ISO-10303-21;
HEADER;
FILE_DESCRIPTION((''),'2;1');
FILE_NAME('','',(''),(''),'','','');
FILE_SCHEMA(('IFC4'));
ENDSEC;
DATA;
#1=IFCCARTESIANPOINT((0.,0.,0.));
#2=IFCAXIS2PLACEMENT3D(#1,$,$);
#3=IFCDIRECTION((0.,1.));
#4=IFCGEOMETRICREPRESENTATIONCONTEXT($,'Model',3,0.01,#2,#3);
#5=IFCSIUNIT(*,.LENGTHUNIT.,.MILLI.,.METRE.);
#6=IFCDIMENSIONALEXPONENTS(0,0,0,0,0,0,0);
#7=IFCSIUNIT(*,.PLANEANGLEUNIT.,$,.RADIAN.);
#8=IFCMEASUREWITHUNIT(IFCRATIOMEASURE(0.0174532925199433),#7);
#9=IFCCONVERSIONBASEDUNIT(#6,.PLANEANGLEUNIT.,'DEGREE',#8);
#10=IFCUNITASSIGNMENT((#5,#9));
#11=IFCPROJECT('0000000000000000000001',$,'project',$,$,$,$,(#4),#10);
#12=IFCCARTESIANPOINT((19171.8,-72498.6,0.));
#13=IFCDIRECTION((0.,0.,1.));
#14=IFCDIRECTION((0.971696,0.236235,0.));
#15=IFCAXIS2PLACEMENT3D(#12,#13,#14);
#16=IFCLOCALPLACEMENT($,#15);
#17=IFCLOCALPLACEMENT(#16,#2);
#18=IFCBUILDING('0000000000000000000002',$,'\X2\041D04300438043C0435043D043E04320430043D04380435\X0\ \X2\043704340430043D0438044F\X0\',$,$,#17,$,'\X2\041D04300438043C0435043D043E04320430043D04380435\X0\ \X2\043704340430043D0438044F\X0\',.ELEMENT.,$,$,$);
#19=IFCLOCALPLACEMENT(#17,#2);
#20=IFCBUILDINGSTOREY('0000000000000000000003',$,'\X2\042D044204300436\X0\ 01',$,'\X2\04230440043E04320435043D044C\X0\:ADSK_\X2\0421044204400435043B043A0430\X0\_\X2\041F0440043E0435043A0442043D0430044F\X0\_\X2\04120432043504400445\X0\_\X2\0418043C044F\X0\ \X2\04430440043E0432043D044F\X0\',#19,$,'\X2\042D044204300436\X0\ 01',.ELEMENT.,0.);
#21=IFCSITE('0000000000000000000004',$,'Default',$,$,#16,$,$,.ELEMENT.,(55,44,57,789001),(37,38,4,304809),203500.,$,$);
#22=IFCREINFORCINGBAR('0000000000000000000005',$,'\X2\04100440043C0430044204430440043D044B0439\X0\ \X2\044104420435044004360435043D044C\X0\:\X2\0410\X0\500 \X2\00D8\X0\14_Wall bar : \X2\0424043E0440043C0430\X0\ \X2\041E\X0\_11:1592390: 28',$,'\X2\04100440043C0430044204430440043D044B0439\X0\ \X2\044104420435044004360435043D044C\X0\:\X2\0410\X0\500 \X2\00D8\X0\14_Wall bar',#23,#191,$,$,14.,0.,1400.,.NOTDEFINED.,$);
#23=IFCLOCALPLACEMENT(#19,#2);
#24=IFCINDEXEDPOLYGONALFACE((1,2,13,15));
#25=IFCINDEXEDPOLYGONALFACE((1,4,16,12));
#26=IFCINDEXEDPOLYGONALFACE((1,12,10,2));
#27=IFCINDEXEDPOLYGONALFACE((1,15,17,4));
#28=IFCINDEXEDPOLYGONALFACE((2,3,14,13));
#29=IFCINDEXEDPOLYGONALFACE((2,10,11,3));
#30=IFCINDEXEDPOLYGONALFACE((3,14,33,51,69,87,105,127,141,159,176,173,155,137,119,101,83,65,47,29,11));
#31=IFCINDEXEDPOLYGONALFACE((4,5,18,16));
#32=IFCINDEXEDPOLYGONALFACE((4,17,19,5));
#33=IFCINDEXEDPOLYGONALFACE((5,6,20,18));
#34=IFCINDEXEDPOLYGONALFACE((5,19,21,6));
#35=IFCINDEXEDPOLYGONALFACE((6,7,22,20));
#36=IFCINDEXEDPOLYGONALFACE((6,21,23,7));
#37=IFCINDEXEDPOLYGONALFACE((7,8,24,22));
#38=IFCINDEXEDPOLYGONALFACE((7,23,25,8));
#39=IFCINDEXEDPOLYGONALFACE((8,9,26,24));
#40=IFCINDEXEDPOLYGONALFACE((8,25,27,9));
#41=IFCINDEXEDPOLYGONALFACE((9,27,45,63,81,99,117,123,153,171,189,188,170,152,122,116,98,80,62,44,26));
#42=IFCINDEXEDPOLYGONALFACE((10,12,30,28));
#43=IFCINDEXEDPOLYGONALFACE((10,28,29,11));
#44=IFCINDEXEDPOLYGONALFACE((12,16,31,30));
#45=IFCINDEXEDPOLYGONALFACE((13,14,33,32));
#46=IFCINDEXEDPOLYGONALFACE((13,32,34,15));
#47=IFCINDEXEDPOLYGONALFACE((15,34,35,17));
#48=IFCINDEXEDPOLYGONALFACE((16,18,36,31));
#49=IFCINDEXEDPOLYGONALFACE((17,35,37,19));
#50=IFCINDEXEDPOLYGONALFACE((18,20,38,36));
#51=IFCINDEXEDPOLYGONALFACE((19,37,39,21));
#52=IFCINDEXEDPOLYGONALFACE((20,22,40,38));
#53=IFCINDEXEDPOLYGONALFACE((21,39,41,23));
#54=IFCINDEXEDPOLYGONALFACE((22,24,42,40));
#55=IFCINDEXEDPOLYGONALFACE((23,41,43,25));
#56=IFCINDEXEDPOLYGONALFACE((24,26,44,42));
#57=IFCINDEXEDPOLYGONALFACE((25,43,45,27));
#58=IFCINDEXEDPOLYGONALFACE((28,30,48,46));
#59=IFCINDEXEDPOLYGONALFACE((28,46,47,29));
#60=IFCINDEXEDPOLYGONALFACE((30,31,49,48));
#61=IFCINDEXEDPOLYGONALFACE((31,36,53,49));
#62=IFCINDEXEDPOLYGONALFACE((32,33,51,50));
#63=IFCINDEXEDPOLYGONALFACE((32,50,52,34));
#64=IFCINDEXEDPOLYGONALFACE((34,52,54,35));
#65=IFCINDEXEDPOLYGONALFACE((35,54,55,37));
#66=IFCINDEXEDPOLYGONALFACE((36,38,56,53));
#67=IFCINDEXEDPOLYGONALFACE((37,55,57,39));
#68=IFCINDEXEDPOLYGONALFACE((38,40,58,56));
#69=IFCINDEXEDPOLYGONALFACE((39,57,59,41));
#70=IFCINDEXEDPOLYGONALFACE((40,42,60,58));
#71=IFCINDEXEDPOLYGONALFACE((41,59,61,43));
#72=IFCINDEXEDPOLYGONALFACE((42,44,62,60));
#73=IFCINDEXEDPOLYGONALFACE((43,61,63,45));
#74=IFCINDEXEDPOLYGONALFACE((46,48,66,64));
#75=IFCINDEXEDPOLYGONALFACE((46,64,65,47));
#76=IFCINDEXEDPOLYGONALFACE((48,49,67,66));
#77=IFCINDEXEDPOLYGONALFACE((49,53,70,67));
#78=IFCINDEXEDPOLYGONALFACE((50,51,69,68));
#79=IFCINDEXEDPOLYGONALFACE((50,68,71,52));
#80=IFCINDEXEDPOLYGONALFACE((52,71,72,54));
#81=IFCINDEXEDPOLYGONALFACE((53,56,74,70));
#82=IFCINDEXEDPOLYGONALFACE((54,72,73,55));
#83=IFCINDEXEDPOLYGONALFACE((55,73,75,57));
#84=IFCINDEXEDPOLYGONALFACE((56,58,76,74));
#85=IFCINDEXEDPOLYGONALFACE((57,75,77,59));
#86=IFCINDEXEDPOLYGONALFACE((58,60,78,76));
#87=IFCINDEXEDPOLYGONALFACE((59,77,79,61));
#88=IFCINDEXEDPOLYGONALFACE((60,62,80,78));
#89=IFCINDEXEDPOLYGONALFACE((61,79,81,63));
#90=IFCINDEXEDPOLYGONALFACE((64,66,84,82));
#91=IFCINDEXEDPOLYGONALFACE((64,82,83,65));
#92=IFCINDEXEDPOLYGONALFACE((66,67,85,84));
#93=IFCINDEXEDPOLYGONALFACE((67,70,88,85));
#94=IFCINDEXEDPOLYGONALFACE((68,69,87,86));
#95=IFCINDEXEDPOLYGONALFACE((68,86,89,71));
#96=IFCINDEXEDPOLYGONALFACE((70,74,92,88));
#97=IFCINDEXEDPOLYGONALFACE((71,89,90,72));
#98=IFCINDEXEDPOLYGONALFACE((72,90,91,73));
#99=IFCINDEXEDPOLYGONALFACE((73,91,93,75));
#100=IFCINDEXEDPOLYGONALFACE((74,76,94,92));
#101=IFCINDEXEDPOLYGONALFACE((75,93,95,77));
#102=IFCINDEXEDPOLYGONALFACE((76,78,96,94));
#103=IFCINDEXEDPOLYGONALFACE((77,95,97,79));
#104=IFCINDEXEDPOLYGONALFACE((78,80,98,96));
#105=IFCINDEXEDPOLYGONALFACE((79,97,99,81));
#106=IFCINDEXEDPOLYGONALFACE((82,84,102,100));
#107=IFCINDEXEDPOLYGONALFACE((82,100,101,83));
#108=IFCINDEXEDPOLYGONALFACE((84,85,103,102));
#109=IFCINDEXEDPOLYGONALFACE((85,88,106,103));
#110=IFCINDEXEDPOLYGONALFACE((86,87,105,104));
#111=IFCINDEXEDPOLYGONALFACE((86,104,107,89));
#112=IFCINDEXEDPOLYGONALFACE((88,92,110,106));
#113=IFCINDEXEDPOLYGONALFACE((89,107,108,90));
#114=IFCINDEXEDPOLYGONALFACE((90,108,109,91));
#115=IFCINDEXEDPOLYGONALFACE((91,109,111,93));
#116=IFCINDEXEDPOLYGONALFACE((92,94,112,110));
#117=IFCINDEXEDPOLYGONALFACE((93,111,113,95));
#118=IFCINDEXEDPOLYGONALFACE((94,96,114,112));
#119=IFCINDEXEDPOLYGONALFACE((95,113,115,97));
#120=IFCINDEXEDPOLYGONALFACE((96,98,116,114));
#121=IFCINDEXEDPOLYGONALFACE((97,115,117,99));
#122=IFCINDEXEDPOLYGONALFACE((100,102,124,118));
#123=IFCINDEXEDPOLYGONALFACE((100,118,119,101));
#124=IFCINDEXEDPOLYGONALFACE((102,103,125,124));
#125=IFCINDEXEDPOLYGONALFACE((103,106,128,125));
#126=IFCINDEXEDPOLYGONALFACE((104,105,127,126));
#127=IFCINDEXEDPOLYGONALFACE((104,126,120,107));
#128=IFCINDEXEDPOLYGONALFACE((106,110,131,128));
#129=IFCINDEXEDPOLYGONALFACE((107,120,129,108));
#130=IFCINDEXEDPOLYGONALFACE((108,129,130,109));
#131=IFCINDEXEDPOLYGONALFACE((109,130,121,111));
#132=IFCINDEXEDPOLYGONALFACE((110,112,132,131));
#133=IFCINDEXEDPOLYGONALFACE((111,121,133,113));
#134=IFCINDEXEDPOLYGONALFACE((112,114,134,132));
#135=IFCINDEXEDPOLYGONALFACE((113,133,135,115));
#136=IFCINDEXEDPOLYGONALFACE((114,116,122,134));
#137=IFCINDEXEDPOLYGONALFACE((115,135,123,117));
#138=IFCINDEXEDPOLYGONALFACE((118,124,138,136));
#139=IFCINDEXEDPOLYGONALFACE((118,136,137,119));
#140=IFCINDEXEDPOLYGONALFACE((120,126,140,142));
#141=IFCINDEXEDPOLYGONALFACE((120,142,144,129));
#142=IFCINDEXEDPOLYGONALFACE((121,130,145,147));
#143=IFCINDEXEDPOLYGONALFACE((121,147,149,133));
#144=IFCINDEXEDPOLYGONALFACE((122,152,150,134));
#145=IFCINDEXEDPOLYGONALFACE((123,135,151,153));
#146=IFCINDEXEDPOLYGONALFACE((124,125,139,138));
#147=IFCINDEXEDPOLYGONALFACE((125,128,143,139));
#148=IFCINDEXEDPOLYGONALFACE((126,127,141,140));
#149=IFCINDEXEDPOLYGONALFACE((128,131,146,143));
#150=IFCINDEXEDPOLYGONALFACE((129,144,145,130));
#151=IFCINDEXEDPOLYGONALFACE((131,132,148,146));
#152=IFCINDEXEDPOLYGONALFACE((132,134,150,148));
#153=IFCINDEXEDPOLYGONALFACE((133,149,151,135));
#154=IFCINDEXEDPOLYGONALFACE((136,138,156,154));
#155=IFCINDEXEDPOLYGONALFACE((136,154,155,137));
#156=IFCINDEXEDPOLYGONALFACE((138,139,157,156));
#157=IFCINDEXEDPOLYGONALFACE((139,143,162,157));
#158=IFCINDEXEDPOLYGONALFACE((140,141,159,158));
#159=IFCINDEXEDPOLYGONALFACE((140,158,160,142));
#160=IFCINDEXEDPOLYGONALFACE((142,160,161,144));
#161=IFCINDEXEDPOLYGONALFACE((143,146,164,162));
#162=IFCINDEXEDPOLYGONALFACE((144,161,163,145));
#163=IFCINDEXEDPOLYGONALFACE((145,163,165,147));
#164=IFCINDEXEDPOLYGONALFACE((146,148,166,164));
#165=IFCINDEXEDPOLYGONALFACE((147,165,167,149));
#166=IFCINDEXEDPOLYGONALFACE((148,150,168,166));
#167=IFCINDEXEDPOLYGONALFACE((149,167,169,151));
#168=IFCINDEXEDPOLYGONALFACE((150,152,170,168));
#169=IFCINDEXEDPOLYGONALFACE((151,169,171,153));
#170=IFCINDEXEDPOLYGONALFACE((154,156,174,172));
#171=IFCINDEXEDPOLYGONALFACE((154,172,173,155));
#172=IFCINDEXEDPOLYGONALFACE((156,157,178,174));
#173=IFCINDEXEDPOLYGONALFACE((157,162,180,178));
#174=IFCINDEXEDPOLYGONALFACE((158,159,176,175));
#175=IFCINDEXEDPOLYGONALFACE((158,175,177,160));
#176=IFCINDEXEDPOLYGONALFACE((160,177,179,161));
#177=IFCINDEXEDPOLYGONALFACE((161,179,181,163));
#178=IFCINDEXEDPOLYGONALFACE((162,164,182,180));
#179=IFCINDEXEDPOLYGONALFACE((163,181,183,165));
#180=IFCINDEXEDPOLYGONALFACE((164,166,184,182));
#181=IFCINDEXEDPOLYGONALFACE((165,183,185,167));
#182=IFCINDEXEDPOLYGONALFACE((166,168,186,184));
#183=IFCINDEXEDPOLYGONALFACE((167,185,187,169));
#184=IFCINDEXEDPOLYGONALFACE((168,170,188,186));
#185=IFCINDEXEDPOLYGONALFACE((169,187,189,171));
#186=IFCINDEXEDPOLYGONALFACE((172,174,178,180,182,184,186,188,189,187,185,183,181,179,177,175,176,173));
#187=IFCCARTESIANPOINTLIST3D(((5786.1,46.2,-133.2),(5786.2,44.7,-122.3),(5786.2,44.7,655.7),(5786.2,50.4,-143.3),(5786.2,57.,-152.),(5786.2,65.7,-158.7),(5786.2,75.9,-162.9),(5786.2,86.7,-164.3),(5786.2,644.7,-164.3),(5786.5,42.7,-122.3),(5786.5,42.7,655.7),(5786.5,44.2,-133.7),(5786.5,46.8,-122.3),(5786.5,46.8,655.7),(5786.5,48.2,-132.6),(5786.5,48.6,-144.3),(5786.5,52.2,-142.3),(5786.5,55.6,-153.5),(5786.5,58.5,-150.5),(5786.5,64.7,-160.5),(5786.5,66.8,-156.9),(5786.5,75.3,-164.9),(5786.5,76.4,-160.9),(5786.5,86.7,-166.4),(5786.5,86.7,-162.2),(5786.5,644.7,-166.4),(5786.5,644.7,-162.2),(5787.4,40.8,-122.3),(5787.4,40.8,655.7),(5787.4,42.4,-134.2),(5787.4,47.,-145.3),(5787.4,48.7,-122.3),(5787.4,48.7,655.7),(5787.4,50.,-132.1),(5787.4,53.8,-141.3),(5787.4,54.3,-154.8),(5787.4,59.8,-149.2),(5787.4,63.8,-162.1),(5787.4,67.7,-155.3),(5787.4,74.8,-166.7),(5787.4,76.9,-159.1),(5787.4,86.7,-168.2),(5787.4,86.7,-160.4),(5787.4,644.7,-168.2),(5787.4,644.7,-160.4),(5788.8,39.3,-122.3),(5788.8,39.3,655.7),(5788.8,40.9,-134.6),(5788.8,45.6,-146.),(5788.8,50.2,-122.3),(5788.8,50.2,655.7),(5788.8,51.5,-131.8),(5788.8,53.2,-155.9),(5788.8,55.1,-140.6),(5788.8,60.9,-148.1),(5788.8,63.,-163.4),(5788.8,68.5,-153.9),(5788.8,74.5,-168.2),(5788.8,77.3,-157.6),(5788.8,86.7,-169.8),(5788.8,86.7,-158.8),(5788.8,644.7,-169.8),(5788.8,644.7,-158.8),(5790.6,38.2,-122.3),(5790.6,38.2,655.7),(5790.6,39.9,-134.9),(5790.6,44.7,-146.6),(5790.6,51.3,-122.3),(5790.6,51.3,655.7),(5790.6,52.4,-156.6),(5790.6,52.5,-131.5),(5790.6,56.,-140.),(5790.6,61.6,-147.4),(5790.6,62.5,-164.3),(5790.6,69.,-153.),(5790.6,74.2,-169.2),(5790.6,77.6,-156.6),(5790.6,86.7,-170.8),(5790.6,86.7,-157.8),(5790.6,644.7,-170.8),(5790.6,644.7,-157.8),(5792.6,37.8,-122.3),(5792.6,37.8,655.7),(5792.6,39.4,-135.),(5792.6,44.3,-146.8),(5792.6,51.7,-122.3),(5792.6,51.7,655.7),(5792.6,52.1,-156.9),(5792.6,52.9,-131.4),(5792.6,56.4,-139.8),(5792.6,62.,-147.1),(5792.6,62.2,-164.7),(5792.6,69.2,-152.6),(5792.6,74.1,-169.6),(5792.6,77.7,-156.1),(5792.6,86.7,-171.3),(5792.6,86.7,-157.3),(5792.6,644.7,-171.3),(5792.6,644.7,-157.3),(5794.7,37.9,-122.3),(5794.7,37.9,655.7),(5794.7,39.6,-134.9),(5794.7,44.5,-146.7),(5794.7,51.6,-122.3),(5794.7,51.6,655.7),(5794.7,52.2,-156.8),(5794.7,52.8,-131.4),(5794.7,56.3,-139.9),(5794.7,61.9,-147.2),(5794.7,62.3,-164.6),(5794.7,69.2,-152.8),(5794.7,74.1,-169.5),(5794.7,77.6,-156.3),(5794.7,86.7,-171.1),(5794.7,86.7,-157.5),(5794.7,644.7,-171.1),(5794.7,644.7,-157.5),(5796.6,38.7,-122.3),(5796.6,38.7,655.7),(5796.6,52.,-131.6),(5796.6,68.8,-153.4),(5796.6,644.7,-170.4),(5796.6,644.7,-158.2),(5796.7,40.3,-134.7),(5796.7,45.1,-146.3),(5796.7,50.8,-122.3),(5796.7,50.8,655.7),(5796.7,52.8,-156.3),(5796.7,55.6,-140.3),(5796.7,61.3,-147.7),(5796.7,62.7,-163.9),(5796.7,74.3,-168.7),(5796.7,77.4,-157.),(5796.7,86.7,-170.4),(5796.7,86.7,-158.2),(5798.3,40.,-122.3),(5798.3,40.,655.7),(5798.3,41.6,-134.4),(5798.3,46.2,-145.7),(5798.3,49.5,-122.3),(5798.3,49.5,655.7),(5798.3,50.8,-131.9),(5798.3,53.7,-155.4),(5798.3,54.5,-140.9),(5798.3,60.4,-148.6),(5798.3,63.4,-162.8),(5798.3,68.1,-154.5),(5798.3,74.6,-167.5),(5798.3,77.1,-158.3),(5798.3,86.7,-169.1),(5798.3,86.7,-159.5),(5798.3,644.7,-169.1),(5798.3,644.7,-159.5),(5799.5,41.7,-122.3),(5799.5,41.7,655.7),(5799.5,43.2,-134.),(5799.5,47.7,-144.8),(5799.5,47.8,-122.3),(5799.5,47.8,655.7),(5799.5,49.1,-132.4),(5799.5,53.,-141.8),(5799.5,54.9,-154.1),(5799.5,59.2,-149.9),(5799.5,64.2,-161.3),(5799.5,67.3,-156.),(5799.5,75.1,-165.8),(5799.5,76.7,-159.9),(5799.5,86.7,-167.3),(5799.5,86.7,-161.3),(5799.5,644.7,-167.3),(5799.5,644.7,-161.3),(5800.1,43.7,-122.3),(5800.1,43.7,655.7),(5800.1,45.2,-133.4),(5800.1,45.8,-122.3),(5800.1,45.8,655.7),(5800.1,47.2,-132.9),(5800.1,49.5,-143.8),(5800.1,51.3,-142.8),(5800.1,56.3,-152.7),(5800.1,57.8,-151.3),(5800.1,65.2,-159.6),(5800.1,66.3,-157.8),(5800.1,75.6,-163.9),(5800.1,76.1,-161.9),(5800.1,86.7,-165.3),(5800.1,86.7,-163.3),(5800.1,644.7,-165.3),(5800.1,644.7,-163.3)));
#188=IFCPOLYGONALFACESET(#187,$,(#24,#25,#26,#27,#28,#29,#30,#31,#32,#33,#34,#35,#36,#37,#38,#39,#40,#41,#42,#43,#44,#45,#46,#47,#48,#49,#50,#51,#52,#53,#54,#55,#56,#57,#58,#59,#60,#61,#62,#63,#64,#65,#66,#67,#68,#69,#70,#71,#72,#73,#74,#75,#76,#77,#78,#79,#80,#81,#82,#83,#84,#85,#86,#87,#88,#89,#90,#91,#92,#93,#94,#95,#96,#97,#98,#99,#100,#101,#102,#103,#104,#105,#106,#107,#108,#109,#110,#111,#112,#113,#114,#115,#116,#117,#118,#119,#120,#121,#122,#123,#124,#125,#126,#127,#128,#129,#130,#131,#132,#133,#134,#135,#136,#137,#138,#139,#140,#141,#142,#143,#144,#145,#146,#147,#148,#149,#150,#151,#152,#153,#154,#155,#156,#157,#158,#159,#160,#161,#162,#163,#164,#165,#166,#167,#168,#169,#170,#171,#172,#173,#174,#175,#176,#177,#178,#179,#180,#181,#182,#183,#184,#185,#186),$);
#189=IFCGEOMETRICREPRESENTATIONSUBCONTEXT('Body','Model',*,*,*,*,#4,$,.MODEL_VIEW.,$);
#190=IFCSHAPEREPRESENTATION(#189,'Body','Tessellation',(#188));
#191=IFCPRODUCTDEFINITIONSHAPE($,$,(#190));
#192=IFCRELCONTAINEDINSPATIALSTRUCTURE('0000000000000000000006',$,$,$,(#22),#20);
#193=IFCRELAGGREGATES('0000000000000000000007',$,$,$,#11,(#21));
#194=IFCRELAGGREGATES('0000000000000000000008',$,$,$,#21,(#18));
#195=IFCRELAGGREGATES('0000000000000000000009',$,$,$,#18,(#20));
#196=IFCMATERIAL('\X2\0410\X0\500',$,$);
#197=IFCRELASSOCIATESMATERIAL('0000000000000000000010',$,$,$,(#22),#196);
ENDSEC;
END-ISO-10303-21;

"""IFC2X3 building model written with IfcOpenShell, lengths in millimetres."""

from ifc_helpers import new_model, entity, si_unit, converted_unit, direction, frame, origin, place, context, subcontext, project, spatial, material, element, save


model = new_model("IFC2X3")

# Units and contexts
model_context = context("Model", 3, precision=0.01, world=origin(), true_north=direction((0.0, 1.0)))
body_context = subcontext(model_context, "Body", "Model", "MODEL_VIEW")
ifc_project = project(units=[si_unit("LENGTHUNIT", "METRE", prefix="MILLI"), converted_unit("PLANEANGLEUNIT", "DEGREE", entity("IfcRatioMeasure", 0.0174532925199433), si_unit("PLANEANGLEUNIT", "RADIAN"), dimensions=[0, 0, 0, 0, 0, 0, 0])], contexts=[model_context])

# Site, building, storey
site_placement = place(None, frame((19171.8, -72498.6, 0.0), z_axis=(0.0, 0.0, 1.0), x_axis=(0.971696, 0.236235, 0.0)))
site = spatial("IfcSite", under=ifc_project, at=site_placement, Name="Default", CompositionType="ELEMENT", RefLatitude=(55, 44, 57, 789001), RefLongitude=(37, 38, 4, 304809), RefElevation=203500.0)
building_placement = place(site_placement, origin())
building = spatial("IfcBuilding", under=site, at=building_placement, Name="Наименование здания", LongName="Наименование здания", CompositionType="ELEMENT")
storey_placement = place(building_placement, origin())
storey = spatial("IfcBuildingStorey", under=building, at=storey_placement, Name="Этаж 01", ObjectType="Уровень:ADSK_Стрелка_Проектная_Вверх_Имя уровня", LongName="Этаж 01", CompositionType="ELEMENT", Elevation=0.0)

# Reinforcing bar
ifc_material = material(Name="А500")
placement = place(storey_placement, origin())
element("IfcReinforcingBar", 1, at=placement, inside=storey, material=ifc_material, Name="Арматурный стержень:А500 Ø14_Wall bar : Форма О_11:1592390: 28", ObjectType="Арматурный стержень:А500 Ø14_Wall bar", BarLength=1400.0, BarRole="NOTDEFINED", CrossSectionArea=0.0, NominalDiameter=14.0, context=body_context, shape_type="AdvancedSweptSolid", body=[
    entity("IfcSweptDiskSolid", entity("IfcCompositeCurve", [entity("IfcCompositeCurveSegment", "CONTINUOUS", True, entity("IfcPolyline", [entity("IfcCartesianPoint", [5793.1, 44.7, 655.7]), entity("IfcCartesianPoint", [5793.1, 44.7, -122.3])])), entity("IfcCompositeCurveSegment", "CONTINUOUS", True, entity("IfcTrimmedCurve", entity("IfcCircle", entity("IfcAxis2Placement3D", entity("IfcCartesianPoint", [5793.1, 86.7, -122.3]), entity("IfcDirection", [1.0, 0.0, 0.0]), entity("IfcDirection", [0.0, 0.0, -1.0])), 42.0), [entity("IfcParameterValue", 270.0)], [entity("IfcParameterValue", 360.0)], True, "PARAMETER")), entity("IfcCompositeCurveSegment", "CONTINUOUS", True, entity("IfcPolyline", [entity("IfcCartesianPoint", [5793.1, 86.7, -164.3]), entity("IfcCartesianPoint", [5793.1, 644.7, -164.3])]))], False), 7.0, None, 0.0, 92.0),
])

save(model, "model.ifc")
